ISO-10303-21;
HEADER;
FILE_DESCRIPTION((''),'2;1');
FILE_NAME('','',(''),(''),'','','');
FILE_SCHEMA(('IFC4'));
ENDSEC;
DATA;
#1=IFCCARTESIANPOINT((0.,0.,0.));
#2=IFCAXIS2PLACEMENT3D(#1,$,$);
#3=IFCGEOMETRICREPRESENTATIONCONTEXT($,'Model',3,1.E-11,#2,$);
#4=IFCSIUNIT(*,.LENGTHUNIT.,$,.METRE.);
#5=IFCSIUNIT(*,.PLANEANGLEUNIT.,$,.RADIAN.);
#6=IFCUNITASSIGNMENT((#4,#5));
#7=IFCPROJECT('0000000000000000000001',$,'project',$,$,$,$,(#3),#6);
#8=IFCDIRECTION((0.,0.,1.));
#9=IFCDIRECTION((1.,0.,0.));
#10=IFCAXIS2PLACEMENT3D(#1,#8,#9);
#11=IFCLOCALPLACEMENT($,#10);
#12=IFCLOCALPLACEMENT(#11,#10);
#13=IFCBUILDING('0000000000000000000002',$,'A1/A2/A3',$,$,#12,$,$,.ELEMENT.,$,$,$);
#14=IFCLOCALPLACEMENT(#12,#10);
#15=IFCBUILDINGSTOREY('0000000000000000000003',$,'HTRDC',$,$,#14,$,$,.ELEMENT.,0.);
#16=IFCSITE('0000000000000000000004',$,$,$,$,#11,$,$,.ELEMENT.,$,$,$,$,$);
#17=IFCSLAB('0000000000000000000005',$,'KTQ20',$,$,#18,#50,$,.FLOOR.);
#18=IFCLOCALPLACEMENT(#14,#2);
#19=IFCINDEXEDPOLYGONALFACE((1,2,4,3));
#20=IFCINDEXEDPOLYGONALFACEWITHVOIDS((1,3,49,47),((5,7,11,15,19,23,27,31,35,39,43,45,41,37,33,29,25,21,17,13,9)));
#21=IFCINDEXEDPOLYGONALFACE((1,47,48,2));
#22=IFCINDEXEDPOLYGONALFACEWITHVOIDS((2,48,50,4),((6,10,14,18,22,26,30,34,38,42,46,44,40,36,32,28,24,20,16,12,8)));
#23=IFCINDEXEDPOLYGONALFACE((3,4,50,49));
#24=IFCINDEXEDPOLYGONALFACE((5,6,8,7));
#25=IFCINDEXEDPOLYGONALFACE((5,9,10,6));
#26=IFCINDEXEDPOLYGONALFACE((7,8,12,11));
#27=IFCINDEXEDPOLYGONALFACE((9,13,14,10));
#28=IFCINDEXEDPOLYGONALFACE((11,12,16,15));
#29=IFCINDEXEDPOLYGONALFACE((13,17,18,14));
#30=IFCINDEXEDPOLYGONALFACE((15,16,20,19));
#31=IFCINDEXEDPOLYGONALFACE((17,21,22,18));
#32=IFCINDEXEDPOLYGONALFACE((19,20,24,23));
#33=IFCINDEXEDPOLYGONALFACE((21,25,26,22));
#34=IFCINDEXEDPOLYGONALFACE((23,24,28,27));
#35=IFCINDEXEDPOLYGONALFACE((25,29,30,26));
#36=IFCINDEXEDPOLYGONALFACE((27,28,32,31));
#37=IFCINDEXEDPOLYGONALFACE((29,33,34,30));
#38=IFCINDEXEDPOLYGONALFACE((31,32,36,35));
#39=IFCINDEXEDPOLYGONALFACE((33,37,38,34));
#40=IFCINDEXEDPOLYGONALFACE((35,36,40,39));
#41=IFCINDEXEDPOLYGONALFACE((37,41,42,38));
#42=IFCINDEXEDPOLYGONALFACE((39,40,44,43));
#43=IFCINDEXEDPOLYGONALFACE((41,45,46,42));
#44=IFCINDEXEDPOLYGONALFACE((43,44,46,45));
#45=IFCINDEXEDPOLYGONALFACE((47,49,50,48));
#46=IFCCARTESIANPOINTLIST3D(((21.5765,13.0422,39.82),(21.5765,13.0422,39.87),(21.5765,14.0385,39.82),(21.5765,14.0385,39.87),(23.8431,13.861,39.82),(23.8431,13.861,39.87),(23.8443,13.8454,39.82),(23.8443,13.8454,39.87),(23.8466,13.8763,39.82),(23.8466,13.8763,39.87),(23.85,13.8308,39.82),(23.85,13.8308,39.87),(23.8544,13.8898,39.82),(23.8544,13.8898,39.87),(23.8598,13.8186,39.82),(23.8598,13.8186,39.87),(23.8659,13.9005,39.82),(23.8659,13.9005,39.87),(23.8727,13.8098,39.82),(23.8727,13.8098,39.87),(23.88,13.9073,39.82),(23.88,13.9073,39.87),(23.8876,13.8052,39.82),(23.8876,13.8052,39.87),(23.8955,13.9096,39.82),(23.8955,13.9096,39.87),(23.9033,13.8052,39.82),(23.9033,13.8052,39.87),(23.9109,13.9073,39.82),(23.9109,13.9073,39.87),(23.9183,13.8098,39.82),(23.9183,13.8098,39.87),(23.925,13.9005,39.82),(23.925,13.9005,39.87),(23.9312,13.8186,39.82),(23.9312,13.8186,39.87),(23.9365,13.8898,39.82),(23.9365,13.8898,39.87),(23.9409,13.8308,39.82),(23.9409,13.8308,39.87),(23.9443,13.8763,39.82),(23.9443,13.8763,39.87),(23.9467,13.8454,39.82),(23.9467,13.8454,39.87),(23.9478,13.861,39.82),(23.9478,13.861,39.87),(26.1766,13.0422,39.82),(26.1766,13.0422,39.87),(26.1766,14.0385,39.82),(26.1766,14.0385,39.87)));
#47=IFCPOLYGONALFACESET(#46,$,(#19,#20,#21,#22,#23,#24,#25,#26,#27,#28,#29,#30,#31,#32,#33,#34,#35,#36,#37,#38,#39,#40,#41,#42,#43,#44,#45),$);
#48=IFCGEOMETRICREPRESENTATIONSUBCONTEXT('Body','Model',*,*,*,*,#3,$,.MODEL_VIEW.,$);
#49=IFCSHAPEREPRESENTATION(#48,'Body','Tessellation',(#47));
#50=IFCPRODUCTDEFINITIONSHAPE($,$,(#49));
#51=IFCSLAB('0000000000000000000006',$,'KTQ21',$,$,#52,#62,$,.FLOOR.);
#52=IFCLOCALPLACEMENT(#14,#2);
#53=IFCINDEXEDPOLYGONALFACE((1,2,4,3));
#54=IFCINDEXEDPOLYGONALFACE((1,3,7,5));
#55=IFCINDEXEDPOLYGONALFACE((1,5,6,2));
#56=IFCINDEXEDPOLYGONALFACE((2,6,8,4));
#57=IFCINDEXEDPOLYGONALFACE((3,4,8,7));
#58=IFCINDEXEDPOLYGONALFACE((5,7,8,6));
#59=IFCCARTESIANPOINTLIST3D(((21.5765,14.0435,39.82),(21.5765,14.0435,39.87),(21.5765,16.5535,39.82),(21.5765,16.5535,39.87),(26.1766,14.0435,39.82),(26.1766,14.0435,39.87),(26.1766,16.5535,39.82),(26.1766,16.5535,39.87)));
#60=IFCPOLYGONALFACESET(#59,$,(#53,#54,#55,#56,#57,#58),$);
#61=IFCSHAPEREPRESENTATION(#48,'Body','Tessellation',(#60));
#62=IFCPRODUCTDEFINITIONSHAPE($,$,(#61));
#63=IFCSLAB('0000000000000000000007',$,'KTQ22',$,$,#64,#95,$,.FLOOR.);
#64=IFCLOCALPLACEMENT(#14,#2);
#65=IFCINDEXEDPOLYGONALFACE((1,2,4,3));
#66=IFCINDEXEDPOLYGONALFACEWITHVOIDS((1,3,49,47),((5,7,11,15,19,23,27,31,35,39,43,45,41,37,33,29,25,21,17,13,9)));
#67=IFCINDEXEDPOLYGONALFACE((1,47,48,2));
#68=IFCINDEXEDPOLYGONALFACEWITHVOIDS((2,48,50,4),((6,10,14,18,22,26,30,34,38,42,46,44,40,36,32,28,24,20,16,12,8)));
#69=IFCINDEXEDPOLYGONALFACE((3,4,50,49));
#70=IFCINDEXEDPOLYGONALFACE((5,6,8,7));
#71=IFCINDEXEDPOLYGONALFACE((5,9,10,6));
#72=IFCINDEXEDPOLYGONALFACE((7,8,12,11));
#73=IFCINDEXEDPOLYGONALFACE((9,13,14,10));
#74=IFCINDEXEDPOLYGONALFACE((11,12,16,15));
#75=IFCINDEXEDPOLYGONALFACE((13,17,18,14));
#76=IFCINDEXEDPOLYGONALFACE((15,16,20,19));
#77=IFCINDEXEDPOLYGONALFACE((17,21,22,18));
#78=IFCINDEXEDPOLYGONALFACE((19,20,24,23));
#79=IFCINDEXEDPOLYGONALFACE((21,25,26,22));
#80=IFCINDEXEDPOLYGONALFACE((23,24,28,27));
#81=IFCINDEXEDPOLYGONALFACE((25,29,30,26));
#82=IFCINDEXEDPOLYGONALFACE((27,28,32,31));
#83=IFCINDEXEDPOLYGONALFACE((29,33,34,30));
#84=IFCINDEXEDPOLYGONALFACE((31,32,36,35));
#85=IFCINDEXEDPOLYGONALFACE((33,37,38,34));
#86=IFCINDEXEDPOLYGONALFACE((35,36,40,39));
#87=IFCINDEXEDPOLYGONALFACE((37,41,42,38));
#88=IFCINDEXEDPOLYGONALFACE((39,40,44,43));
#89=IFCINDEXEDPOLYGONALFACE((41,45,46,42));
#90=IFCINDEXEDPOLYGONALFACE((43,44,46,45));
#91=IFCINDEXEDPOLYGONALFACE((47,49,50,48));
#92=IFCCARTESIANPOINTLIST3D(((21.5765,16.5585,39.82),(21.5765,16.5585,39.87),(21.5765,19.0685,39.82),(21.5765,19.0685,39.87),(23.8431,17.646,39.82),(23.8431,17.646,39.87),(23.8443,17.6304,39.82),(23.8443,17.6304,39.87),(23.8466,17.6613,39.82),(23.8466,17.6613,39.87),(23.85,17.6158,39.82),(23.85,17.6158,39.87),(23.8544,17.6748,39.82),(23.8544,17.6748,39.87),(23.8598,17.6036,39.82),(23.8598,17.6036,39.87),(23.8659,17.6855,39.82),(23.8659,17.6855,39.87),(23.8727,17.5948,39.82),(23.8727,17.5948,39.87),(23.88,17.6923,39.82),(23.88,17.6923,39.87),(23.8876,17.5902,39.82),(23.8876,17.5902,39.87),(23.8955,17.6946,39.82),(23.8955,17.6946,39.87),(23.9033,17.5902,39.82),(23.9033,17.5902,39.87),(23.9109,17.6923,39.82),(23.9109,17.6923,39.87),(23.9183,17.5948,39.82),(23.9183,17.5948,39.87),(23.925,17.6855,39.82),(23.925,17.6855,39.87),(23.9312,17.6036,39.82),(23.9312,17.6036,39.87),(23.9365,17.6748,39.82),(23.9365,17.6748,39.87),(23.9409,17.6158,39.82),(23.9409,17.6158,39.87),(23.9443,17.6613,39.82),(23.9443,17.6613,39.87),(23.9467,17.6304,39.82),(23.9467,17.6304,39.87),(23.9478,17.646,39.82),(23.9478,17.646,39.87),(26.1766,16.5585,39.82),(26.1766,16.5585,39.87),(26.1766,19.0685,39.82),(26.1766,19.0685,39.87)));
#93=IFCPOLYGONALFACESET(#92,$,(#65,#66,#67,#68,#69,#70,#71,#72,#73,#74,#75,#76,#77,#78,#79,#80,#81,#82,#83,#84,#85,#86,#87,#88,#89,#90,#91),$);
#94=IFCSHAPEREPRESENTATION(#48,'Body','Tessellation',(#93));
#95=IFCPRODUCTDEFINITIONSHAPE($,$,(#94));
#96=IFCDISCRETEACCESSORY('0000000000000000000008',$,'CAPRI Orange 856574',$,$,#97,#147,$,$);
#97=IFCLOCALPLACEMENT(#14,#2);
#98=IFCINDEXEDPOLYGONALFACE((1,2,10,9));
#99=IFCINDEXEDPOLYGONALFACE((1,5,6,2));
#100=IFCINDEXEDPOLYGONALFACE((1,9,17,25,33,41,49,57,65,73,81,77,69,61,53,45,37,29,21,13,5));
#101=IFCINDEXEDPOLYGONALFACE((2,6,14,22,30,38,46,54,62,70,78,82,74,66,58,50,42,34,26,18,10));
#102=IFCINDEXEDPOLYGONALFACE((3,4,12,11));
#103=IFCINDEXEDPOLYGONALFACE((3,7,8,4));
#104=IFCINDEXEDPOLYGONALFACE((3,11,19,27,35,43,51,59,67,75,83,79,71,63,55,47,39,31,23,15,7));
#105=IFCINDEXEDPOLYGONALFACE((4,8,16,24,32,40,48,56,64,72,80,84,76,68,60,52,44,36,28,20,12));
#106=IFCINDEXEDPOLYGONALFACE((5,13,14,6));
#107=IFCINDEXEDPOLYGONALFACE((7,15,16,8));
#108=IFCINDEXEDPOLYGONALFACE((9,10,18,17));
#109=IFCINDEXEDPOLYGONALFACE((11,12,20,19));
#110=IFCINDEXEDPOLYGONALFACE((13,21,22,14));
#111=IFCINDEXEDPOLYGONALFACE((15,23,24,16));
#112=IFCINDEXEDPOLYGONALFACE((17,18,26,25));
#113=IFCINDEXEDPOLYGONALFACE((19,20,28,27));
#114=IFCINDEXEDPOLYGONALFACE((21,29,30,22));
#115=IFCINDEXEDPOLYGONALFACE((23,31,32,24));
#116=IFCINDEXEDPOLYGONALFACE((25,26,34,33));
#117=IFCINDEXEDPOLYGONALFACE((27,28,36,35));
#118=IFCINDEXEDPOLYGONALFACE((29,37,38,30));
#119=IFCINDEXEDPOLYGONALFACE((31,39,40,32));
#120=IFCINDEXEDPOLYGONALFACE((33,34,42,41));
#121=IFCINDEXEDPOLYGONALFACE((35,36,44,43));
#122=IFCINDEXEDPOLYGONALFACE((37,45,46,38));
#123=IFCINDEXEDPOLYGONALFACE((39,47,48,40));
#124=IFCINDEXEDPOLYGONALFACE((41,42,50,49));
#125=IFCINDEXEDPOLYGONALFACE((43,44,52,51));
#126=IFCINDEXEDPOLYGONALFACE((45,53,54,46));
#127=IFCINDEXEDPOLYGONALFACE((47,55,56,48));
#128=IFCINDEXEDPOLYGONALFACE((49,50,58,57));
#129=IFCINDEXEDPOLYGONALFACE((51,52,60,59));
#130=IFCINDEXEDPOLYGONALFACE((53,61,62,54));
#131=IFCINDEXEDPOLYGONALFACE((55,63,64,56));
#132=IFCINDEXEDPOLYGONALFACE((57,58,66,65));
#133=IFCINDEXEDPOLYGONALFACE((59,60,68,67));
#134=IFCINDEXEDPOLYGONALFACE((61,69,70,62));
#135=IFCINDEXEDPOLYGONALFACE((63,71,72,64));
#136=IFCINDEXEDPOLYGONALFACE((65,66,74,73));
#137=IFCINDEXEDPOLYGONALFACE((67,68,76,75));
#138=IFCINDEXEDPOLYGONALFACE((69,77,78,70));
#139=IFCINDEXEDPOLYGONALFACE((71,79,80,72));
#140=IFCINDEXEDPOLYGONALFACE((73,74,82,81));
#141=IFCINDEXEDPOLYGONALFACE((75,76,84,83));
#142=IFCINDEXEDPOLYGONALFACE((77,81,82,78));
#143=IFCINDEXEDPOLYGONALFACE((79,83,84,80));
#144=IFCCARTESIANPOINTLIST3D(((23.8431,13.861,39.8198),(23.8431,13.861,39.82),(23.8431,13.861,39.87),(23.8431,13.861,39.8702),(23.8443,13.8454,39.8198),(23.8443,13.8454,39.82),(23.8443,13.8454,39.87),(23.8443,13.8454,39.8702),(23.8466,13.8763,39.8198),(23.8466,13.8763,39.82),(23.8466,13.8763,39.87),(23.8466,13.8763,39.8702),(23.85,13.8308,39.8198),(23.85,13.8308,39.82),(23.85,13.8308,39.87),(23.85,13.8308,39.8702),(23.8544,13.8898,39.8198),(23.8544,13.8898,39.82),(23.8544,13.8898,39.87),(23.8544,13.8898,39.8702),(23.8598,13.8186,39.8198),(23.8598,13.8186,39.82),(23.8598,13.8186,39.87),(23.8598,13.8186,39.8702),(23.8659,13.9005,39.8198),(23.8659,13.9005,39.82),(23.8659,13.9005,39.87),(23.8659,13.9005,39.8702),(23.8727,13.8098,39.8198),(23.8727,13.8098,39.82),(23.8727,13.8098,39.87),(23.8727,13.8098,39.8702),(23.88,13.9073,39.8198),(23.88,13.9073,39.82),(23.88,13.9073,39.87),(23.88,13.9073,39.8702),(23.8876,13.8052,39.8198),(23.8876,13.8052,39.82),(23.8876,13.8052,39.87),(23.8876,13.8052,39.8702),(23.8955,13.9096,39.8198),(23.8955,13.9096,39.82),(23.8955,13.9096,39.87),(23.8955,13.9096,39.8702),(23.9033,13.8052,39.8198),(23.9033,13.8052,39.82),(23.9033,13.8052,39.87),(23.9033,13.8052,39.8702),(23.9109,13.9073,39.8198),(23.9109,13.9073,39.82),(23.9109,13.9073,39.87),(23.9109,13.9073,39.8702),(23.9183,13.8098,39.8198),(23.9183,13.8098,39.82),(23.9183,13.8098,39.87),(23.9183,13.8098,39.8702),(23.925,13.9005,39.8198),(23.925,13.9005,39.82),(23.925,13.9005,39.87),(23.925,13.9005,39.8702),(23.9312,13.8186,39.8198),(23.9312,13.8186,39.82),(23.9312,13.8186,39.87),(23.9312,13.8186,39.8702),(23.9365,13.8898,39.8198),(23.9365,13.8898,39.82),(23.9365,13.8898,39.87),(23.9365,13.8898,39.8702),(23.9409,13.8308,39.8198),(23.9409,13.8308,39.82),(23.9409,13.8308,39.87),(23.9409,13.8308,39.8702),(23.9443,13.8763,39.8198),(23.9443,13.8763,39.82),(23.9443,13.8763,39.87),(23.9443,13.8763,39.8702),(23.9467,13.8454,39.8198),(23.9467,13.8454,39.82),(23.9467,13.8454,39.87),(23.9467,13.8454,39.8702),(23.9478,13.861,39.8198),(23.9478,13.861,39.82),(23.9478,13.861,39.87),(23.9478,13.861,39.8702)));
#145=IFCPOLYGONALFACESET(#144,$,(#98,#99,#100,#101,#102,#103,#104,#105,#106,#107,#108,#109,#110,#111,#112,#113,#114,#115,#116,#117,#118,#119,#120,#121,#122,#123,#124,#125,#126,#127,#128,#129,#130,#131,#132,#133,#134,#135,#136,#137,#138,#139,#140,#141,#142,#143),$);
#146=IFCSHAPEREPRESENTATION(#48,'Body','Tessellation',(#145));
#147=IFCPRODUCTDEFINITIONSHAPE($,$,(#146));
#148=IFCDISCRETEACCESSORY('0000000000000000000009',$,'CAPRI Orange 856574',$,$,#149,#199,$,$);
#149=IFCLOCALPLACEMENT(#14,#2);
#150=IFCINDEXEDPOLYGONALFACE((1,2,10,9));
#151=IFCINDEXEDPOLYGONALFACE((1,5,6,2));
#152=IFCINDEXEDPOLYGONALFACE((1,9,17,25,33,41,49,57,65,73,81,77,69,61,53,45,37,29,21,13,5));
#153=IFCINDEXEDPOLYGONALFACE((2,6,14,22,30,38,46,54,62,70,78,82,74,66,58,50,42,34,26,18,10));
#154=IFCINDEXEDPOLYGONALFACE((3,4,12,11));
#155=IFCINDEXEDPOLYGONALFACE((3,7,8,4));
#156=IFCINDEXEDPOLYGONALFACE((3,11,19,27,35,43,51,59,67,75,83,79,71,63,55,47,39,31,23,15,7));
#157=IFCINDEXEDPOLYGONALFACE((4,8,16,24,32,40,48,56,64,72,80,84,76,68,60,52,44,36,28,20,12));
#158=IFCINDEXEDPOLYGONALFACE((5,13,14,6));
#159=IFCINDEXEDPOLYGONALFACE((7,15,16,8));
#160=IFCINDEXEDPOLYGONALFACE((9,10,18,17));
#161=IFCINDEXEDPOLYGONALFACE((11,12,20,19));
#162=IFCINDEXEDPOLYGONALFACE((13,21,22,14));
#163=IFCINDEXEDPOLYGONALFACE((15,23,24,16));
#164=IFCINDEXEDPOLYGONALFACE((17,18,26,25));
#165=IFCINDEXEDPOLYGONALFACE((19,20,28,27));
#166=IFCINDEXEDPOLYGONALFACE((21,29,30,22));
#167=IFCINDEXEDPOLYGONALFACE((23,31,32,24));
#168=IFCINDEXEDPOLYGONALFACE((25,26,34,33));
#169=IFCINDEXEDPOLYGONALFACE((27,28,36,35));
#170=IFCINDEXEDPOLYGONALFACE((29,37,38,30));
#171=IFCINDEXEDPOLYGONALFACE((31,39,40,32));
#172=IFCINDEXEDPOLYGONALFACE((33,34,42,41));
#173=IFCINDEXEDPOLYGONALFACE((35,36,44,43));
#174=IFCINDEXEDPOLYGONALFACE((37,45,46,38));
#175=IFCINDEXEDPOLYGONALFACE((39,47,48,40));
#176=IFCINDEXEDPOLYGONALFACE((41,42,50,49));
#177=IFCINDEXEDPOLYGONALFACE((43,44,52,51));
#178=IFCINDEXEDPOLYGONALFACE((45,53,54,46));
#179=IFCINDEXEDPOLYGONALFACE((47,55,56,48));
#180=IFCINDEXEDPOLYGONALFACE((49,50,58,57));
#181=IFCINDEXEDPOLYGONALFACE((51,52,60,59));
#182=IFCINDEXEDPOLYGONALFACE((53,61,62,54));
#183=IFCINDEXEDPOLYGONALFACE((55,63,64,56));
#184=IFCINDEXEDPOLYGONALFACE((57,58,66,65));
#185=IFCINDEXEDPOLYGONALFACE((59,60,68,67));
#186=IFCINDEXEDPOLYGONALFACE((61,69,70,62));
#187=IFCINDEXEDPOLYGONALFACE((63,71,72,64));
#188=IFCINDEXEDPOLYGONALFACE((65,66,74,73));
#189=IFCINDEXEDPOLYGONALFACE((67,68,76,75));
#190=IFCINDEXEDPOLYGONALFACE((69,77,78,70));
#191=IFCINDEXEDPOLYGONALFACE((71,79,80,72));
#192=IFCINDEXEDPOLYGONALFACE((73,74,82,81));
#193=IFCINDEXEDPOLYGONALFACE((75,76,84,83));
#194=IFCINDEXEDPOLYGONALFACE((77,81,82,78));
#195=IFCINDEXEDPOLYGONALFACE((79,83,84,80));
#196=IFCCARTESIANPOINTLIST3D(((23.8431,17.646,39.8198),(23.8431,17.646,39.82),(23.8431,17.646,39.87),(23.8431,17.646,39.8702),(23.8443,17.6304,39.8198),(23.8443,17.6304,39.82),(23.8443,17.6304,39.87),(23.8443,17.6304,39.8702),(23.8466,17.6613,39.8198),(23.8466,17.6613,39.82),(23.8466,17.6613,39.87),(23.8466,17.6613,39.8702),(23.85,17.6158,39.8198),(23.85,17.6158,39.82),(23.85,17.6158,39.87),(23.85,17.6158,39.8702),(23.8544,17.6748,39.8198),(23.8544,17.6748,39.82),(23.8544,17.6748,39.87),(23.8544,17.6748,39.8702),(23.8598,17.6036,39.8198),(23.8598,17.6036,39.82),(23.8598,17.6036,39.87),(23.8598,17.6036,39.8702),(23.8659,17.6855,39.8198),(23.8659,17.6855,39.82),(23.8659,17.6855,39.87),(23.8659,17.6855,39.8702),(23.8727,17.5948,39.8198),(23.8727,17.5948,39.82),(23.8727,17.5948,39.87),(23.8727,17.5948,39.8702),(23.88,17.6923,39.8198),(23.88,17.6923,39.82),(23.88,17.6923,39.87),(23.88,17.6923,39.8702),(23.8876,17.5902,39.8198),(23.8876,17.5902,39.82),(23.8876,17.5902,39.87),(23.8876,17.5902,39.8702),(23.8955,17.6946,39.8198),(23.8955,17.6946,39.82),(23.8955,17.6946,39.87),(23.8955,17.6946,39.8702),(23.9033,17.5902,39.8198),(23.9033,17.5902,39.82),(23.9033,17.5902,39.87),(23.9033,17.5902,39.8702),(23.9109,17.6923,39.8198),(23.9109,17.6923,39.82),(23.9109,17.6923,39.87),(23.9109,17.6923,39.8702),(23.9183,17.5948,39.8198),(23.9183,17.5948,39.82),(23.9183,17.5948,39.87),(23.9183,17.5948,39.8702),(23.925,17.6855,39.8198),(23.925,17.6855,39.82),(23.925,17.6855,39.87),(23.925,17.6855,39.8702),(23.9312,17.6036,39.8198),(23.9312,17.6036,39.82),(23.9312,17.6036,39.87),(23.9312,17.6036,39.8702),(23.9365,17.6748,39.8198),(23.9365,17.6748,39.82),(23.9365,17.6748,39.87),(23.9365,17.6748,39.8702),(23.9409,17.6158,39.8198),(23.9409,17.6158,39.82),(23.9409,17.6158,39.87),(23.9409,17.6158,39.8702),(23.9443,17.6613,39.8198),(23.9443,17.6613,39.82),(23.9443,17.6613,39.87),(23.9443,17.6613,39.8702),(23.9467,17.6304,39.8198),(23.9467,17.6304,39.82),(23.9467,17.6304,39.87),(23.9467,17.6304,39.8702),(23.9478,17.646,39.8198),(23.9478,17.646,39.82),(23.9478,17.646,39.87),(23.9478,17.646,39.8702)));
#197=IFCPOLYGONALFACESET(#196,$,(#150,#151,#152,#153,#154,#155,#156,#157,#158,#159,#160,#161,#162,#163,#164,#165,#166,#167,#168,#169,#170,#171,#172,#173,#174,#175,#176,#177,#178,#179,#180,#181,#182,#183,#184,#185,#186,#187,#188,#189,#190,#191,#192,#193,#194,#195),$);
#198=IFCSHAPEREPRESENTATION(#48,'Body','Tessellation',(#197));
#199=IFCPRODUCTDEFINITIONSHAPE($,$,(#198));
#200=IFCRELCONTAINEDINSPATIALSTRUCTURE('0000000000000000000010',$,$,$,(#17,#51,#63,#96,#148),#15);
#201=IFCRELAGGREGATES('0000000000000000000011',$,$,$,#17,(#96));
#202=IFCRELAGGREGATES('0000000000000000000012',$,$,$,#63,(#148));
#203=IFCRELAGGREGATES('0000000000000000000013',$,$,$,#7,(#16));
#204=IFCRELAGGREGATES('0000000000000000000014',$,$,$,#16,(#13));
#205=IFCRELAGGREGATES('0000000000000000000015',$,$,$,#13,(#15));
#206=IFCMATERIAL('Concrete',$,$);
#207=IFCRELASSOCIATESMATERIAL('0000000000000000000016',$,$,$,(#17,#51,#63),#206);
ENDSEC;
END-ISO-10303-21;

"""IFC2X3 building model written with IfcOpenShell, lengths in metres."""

from ifc_helpers import new_model, si_unit, frame, frame_2d, origin, origin_with_axes, origin_2d_with_axis, place, context, subcontext, project, spatial, polyline, circle, outline, extrude, material, element, aggregate, save


model = new_model("IFC2X3")

# Units and contexts
model_context = context("Model", 3, precision=1e-11, world=origin())
body_context = subcontext(model_context, "Body", "Model", "MODEL_VIEW")
ifc_project = project(units=[si_unit("LENGTHUNIT", "METRE"), si_unit("PLANEANGLEUNIT", "RADIAN")], contexts=[model_context])

# Site, building, storey
site_placement = place(None, origin_with_axes())
site = spatial("IfcSite", under=ifc_project, at=site_placement, CompositionType="ELEMENT")
building_placement = place(site_placement, origin_with_axes())
building = spatial("IfcBuilding", under=site, at=building_placement, Name="A1/A2/A3", CompositionType="ELEMENT")
storey_placement = place(building_placement, origin_with_axes())
storey = spatial("IfcBuildingStorey", under=building, at=storey_placement, Name="HTRDC", CompositionType="ELEMENT", Elevation=0.0)

# Slab, opening
ifc_material = material(Name="Concrete")
slab_1_placement = place(storey_placement, frame((21.5765, 13.0422, 39.82), z_axis=(0.0, 0.0, 1.0), x_axis=(1.0, 0.0, 0.0)))
slab_1 = element("IfcSlab", 1, at=slab_1_placement, inside=storey, material=ifc_material, Name="KTQ20", PredefinedType="FLOOR", context=body_context, shape_type="SweptSolid", body=[
    extrude(outline(polyline([(0.0, 0.0), (0.0, -4.6001), (0.9963, -4.6001), (0.9963, 0.0), (0.0, 0.0)])), frame((0.0, 0.0, 0.0), z_axis=(0.0, 0.0, 1.0), x_axis=(0.0, 1.0, 0.0)), (0.0, 0.0, 1.0), 0.05),
])
opening_1_placement = place(slab_1_placement, frame((2.319, 0.8149, 0.0), z_axis=(0.0, 0.0, 1.0), x_axis=(1.0, 0.0, 0.0)))
element("IfcOpeningElement", 2, at=opening_1_placement, cuts=slab_1, ObjectType="Opening", context=body_context, shape_type="SweptSolid", body=[
    extrude(circle(Radius=0.0525, at=origin_2d_with_axis()), frame((0.0, 0.0, 0.0), z_axis=(0.0, 0.0, 1.0), x_axis=(0.0, 1.0, 0.0)), (0.0, 0.0, 1.0), 0.05),
])

# Slab
slab_2_placement = place(storey_placement, frame((21.5765, 14.0435, 39.82), z_axis=(0.0, 0.0, 1.0), x_axis=(1.0, 0.0, 0.0)))
element("IfcSlab", 3, at=slab_2_placement, inside=storey, material=ifc_material, Name="KTQ21", PredefinedType="FLOOR", context=body_context, shape_type="SweptSolid", body=[
    extrude(outline(polyline([(0.0, 0.0), (0.0, -4.6001), (2.51, -4.6001), (2.51, 0.0), (0.0, 0.0)])), frame((0.0, 0.0, 0.0), z_axis=(0.0, 0.0, 1.0), x_axis=(0.0, 1.0, 0.0)), (0.0, 0.0, 1.0), 0.05),
])

# Slab, opening
slab_3_placement = place(storey_placement, frame((21.5765, 16.5585, 39.82), z_axis=(0.0, 0.0, 1.0), x_axis=(1.0, 0.0, 0.0)))
slab_3 = element("IfcSlab", 4, at=slab_3_placement, inside=storey, material=ifc_material, Name="KTQ22", PredefinedType="FLOOR", context=body_context, shape_type="SweptSolid", body=[
    extrude(outline(polyline([(0.0, 0.0), (0.0, -4.6001), (2.51, -4.6001), (2.51, 0.0), (0.0, 0.0)])), frame((0.0, 0.0, 0.0), z_axis=(0.0, 0.0, 1.0), x_axis=(0.0, 1.0, 0.0)), (0.0, 0.0, 1.0), 0.05),
])
opening_2_placement = place(slab_3_placement, frame((2.319, 1.0836, 0.0), z_axis=(0.0, 0.0, 1.0), x_axis=(1.0, 0.0, 0.0)))
element("IfcOpeningElement", 5, at=opening_2_placement, cuts=slab_3, ObjectType="Opening", context=body_context, shape_type="SweptSolid", body=[
    extrude(circle(Radius=0.0525, at=origin_2d_with_axis()), frame((0.0, 0.0, 0.0), z_axis=(0.0, 0.0, 1.0), x_axis=(0.0, 1.0, 0.0)), (0.0, 0.0, 1.0), 0.05),
])

# Discrete accessories
discrete_accessory_1_placement = place(storey_placement, frame((21.5765, 13.0422, 39.8199), z_axis=(0.0, 0.0, 1.0), x_axis=(1.0, 0.0, 0.0)))
discrete_accessory_1 = element("IfcDiscreteAccessory", 6, at=discrete_accessory_1_placement, inside=storey, Name="CAPRI Orange 856574", context=body_context, shape_type="SweptSolid", body=[
    extrude(circle(Radius=0.0525, at=frame_2d((0.8149, -2.319), x_axis=(1.0, 0.0))), frame((0.0, 0.0, 0.0), z_axis=(0.0, 0.0, 1.0), x_axis=(0.0, 1.0, 0.0)), (0.0, 0.0, 1.0), 0.0503),
])
aggregate(slab_1, [discrete_accessory_1])
discrete_accessory_2_placement = place(storey_placement, frame((21.5765, 16.5585, 39.8199), z_axis=(0.0, 0.0, 1.0), x_axis=(1.0, 0.0, 0.0)))
discrete_accessory_2 = element("IfcDiscreteAccessory", 7, at=discrete_accessory_2_placement, inside=storey, Name="CAPRI Orange 856574", context=body_context, shape_type="SweptSolid", body=[
    extrude(circle(Radius=0.0525, at=frame_2d((1.0836, -2.319), x_axis=(1.0, 0.0))), frame((0.0, 0.0, 0.0), z_axis=(0.0, 0.0, 1.0), x_axis=(0.0, 1.0, 0.0)), (0.0, 0.0, 1.0), 0.0503),
])
aggregate(slab_3, [discrete_accessory_2])

save(model, "model.ifc")
